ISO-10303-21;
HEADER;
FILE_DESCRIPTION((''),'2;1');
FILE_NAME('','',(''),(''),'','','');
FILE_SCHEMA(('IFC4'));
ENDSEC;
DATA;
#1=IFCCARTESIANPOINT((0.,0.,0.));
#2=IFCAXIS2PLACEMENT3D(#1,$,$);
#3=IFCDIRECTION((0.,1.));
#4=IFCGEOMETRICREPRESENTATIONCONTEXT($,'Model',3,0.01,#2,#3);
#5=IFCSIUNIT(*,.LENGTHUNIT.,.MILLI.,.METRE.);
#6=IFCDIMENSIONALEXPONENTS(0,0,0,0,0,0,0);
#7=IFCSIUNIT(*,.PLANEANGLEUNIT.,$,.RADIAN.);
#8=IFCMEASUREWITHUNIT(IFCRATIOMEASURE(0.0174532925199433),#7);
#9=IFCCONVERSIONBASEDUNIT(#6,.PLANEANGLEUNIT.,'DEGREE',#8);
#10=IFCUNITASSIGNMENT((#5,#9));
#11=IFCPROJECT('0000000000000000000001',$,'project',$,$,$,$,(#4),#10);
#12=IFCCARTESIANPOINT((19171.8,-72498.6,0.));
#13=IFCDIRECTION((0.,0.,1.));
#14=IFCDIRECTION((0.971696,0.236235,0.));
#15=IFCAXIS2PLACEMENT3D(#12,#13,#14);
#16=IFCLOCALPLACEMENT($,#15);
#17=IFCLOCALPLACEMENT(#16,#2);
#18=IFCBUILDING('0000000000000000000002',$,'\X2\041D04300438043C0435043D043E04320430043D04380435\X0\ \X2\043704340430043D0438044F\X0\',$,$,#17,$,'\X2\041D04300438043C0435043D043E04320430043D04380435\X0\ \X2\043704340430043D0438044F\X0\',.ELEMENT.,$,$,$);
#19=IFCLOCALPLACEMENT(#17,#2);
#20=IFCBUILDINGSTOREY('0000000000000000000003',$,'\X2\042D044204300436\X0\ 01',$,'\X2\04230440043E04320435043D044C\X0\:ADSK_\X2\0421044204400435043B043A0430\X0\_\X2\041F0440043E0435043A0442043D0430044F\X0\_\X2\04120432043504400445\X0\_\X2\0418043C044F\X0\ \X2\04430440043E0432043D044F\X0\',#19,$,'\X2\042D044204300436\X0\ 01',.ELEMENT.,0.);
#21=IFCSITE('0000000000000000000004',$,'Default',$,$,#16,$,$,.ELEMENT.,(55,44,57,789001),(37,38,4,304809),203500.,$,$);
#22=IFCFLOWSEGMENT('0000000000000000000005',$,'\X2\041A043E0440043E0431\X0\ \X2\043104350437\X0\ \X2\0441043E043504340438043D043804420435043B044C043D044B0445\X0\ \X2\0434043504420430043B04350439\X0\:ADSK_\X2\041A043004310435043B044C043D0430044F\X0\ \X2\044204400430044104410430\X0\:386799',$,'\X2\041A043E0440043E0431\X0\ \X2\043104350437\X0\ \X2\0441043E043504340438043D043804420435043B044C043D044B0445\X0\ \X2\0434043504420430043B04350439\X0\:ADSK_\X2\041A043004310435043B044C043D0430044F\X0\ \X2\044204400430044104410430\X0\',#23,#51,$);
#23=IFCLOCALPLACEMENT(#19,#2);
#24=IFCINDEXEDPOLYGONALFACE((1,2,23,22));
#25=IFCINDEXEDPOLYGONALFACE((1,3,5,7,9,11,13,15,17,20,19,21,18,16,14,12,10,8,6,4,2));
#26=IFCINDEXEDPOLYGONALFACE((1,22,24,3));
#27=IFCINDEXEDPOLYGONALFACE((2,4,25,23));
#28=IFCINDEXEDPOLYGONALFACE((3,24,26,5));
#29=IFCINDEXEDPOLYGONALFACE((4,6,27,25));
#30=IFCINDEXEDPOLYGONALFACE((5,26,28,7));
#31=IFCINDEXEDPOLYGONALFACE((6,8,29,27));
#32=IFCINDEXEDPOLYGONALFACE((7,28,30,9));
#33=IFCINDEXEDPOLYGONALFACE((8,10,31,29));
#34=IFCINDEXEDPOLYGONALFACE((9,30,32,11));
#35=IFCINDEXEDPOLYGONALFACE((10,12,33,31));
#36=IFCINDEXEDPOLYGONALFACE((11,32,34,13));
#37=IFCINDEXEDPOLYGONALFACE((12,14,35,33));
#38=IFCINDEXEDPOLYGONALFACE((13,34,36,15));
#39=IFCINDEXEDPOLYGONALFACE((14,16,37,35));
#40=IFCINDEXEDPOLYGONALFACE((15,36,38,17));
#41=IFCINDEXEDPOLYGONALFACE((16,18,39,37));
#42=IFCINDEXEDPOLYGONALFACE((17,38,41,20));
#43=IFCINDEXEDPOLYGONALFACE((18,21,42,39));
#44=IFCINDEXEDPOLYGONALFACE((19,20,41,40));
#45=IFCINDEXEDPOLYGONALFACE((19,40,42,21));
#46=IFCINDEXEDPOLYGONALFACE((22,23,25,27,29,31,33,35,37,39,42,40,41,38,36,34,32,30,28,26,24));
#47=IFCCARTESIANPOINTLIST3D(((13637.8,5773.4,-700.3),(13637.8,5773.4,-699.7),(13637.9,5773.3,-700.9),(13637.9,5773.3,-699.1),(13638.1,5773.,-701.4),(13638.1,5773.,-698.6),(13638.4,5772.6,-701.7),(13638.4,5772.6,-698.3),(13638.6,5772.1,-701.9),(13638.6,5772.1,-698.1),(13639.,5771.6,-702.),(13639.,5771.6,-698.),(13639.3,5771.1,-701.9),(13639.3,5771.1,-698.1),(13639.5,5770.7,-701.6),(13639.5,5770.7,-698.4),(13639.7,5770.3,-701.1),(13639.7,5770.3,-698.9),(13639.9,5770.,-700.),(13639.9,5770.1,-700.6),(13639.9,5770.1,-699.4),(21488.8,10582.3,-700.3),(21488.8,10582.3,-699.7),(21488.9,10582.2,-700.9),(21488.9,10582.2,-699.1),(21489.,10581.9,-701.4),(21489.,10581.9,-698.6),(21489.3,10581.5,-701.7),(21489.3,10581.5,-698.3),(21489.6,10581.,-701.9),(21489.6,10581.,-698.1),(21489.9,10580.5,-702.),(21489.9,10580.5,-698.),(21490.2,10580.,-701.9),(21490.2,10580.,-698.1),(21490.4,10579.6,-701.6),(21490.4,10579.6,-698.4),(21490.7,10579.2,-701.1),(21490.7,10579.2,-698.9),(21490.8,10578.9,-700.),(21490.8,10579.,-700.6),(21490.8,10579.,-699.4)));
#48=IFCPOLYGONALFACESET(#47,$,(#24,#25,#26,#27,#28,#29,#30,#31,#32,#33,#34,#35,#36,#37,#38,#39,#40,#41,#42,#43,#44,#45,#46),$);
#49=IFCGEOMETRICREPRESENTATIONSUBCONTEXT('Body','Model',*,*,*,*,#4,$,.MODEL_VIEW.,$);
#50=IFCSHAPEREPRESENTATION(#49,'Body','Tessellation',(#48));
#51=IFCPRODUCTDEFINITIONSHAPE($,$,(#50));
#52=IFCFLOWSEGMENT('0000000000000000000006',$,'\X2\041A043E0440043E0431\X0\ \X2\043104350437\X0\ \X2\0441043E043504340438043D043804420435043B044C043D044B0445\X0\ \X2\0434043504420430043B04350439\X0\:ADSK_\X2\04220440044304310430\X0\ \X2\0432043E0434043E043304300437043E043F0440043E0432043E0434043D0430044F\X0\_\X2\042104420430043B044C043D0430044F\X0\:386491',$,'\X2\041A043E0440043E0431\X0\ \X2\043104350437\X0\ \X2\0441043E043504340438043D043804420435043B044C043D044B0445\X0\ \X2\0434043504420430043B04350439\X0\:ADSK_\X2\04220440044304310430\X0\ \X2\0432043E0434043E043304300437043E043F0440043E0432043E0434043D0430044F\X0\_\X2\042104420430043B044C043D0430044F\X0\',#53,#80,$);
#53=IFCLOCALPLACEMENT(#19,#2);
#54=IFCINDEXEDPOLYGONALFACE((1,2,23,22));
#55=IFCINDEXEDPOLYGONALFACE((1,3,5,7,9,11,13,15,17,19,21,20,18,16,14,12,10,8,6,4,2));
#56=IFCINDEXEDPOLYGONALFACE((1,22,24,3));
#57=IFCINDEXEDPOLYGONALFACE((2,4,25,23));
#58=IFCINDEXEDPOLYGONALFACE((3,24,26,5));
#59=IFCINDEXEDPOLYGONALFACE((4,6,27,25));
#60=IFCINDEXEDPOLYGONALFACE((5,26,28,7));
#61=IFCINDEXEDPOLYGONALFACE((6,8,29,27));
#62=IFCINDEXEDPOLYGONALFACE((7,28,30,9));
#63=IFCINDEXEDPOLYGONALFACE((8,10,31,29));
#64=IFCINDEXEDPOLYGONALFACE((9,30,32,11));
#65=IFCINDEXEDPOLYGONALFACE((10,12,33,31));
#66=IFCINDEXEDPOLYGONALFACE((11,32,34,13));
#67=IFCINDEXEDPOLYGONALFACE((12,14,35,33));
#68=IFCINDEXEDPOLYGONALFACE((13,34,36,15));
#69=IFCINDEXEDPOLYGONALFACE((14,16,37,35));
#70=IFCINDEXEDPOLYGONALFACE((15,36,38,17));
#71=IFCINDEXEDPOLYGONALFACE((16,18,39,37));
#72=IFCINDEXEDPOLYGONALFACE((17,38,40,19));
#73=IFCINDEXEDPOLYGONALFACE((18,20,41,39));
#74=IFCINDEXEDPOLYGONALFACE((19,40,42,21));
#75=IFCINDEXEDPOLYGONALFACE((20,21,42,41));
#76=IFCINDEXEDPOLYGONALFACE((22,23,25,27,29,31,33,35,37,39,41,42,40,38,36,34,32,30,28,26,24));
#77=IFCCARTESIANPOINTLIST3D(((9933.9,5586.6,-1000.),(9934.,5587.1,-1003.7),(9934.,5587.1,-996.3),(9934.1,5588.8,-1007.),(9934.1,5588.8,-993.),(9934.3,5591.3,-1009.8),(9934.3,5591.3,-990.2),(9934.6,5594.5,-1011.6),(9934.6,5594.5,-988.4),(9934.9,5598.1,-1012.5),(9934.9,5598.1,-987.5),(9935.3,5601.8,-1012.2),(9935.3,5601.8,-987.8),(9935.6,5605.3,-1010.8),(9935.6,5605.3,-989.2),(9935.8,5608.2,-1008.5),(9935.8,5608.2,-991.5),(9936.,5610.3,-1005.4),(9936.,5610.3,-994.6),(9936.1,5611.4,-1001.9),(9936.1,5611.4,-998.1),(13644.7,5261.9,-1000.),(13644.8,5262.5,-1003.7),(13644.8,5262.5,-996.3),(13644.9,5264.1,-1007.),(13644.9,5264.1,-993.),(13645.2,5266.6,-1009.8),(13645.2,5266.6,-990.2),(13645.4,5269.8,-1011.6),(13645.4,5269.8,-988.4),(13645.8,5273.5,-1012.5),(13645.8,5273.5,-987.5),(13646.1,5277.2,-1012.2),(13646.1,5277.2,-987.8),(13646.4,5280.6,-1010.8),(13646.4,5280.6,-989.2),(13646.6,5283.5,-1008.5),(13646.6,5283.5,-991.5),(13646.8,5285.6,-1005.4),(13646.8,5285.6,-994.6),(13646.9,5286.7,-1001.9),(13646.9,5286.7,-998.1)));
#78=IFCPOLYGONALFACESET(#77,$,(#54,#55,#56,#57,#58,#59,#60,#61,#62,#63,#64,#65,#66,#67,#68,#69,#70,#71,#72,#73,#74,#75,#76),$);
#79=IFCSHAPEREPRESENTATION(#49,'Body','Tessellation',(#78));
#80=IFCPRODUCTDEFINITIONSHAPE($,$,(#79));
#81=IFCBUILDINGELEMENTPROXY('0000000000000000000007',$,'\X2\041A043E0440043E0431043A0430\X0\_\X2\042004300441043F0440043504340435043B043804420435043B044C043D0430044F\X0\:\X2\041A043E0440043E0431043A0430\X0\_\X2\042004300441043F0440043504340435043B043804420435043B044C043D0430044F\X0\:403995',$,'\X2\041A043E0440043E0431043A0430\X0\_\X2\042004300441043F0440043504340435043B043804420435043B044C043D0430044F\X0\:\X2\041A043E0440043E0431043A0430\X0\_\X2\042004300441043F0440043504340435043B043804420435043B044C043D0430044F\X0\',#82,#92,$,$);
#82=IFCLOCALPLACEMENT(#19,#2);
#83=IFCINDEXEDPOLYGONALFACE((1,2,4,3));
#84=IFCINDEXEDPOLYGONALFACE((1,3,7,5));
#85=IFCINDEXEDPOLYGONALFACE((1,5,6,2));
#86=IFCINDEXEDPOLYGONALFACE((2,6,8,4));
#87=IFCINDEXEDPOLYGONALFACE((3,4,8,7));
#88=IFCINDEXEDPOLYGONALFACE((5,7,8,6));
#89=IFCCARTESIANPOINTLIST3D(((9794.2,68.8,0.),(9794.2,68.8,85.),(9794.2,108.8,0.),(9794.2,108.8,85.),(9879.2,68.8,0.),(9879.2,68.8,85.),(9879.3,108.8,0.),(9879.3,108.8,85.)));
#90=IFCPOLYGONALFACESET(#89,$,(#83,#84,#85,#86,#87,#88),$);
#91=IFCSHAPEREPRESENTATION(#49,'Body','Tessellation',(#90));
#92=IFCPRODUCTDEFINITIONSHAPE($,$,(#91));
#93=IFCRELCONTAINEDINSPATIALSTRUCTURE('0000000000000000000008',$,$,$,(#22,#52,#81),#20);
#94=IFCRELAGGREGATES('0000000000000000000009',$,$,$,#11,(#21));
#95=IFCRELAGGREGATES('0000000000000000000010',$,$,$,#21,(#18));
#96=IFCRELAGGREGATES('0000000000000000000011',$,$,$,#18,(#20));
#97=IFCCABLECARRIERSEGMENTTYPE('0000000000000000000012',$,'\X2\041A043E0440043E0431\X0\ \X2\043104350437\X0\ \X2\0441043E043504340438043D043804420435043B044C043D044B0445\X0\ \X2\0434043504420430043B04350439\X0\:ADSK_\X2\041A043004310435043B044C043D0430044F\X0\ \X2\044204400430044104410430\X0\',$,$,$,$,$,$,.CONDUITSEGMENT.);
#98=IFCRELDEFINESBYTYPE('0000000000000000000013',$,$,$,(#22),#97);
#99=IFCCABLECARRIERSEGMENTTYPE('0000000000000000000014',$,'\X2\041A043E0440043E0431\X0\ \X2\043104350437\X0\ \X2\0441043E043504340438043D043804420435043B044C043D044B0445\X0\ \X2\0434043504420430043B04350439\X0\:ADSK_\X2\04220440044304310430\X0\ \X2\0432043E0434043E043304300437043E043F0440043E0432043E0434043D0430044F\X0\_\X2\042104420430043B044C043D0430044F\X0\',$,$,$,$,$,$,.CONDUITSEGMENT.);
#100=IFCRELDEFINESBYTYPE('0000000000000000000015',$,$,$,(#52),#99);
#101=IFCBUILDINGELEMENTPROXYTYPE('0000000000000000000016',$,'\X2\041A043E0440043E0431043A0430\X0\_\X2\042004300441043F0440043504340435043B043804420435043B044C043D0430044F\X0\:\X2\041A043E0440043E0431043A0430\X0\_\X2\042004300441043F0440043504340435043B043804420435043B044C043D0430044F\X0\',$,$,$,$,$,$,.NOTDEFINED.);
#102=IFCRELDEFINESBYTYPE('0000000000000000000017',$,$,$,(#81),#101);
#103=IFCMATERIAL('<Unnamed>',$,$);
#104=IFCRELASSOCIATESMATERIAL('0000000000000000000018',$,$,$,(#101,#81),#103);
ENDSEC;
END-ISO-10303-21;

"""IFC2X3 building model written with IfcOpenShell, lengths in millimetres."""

from ifc_helpers import new_model, entity, si_unit, converted_unit, direction, frame, origin, origin_2d_with_axis, place, context, subcontext, project, spatial, rectangle, circle, extrude, source, transform, mapped, material, type_object, type_shapes, element, save


model = new_model("IFC2X3")

# Units and contexts
model_context = context("Model", 3, precision=0.01, world=origin(), true_north=direction((0.0, 1.0)))
body_context = subcontext(model_context, "Body", "Model", "MODEL_VIEW")
ifc_project = project(units=[si_unit("LENGTHUNIT", "METRE", prefix="MILLI"), converted_unit("PLANEANGLEUNIT", "DEGREE", entity("IfcRatioMeasure", 0.0174532925199433), si_unit("PLANEANGLEUNIT", "RADIAN"), dimensions=[0, 0, 0, 0, 0, 0, 0])], contexts=[model_context])

# Site, building, storey
site_placement = place(None, frame((19171.8, -72498.6, 0.0), z_axis=(0.0, 0.0, 1.0), x_axis=(0.971696, 0.236235, 0.0)))
site = spatial("IfcSite", under=ifc_project, at=site_placement, Name="Default", CompositionType="ELEMENT", RefLatitude=(55, 44, 57, 789001), RefLongitude=(37, 38, 4, 304809), RefElevation=203500.0)
building_placement = place(site_placement, origin())
building = spatial("IfcBuilding", under=site, at=building_placement, Name="Наименование здания", LongName="Наименование здания", CompositionType="ELEMENT")
storey_placement = place(building_placement, origin())
storey = spatial("IfcBuildingStorey", under=building, at=storey_placement, Name="Этаж 01", ObjectType="Уровень:ADSK_Стрелка_Проектная_Вверх_Имя уровня", LongName="Этаж 01", CompositionType="ELEMENT", Elevation=0.0)

# Flow segments
cable_carrier_segment_type_1 = type_object("IfcCableCarrierSegmentType", Name="Короб без соединительных деталей:ADSK_Кабельная трасса", PredefinedType="CONDUITSEGMENT")
flow_segment_1_placement = place(storey_placement, frame((13636.2, 5768.4, -703.6)))
element("IfcFlowSegment", 1, at=flow_segment_1_placement, inside=storey, type_object=cable_carrier_segment_type_1, Name="Короб без соединительных деталей:ADSK_Кабельная трасса:386799", ObjectType="Короб без соединительных деталей:ADSK_Кабельная трасса", context=body_context, shape_type="SweptSolid", body=[
    extrude(circle(Radius=2.0, at=origin_2d_with_axis()), frame((2.6, 3.3, 3.6), z_axis=(0.852745, 0.522328, 0.0), x_axis=(0.522328, -0.852745, 0.0)), (0.0, 0.0, 1.0), 9206.6),
])
cable_carrier_segment_type_2 = type_object("IfcCableCarrierSegmentType", Name="Короб без соединительных деталей:ADSK_Труба водогазопроводная_Стальная", PredefinedType="CONDUITSEGMENT")
flow_segment_2_placement = place(storey_placement, frame((9932.3, 5260.3, -1014.1)))
element("IfcFlowSegment", 2, at=flow_segment_2_placement, inside=storey, type_object=cable_carrier_segment_type_2, Name="Короб без соединительных деталей:ADSK_Труба водогазопроводная_Стальная:386491", ObjectType="Короб без соединительных деталей:ADSK_Труба водогазопроводная_Стальная", context=body_context, shape_type="SweptSolid", body=[
    extrude(circle(Radius=12.5, at=origin_2d_with_axis()), frame((2.7, 338.7, 14.1), z_axis=(0.996195, -0.087156, 0.0), x_axis=(-0.087156, -0.996195, 0.0)), (0.0, 0.0, 1.0), 3725.0),
])

# Building element proxy
ifc_material = material(Name="<Unnamed>")
building_element_proxy_type = type_object("IfcBuildingElementProxyType", Name="Коробка_Распределительная:Коробка_Распределительная", PredefinedType="NOTDEFINED", material=ifc_material)
shared_shape = source(origin(), body_context, "Body", "SweptSolid", [
    extrude(rectangle(XDim=85.0, YDim=40.0, at=origin_2d_with_axis()), origin(), (0.0, 0.0, 1.0), 85.0),
])
type_shapes(building_element_proxy_type, [shared_shape])
proxy_placement = place(storey_placement, frame((9836.8, 88.8, 0.0)))
element("IfcBuildingElementProxy", 3, at=proxy_placement, inside=storey, type_object=building_element_proxy_type, material=ifc_material, Name="Коробка_Распределительная:Коробка_Распределительная:403995", ObjectType="Коробка_Распределительная:Коробка_Распределительная", context=body_context, shape_type="MappedRepresentation", body=[
    mapped(shared_shape, transform((0.0, 0.0, 0.0), scale=1.0)),
])

save(model, "model.ifc")
